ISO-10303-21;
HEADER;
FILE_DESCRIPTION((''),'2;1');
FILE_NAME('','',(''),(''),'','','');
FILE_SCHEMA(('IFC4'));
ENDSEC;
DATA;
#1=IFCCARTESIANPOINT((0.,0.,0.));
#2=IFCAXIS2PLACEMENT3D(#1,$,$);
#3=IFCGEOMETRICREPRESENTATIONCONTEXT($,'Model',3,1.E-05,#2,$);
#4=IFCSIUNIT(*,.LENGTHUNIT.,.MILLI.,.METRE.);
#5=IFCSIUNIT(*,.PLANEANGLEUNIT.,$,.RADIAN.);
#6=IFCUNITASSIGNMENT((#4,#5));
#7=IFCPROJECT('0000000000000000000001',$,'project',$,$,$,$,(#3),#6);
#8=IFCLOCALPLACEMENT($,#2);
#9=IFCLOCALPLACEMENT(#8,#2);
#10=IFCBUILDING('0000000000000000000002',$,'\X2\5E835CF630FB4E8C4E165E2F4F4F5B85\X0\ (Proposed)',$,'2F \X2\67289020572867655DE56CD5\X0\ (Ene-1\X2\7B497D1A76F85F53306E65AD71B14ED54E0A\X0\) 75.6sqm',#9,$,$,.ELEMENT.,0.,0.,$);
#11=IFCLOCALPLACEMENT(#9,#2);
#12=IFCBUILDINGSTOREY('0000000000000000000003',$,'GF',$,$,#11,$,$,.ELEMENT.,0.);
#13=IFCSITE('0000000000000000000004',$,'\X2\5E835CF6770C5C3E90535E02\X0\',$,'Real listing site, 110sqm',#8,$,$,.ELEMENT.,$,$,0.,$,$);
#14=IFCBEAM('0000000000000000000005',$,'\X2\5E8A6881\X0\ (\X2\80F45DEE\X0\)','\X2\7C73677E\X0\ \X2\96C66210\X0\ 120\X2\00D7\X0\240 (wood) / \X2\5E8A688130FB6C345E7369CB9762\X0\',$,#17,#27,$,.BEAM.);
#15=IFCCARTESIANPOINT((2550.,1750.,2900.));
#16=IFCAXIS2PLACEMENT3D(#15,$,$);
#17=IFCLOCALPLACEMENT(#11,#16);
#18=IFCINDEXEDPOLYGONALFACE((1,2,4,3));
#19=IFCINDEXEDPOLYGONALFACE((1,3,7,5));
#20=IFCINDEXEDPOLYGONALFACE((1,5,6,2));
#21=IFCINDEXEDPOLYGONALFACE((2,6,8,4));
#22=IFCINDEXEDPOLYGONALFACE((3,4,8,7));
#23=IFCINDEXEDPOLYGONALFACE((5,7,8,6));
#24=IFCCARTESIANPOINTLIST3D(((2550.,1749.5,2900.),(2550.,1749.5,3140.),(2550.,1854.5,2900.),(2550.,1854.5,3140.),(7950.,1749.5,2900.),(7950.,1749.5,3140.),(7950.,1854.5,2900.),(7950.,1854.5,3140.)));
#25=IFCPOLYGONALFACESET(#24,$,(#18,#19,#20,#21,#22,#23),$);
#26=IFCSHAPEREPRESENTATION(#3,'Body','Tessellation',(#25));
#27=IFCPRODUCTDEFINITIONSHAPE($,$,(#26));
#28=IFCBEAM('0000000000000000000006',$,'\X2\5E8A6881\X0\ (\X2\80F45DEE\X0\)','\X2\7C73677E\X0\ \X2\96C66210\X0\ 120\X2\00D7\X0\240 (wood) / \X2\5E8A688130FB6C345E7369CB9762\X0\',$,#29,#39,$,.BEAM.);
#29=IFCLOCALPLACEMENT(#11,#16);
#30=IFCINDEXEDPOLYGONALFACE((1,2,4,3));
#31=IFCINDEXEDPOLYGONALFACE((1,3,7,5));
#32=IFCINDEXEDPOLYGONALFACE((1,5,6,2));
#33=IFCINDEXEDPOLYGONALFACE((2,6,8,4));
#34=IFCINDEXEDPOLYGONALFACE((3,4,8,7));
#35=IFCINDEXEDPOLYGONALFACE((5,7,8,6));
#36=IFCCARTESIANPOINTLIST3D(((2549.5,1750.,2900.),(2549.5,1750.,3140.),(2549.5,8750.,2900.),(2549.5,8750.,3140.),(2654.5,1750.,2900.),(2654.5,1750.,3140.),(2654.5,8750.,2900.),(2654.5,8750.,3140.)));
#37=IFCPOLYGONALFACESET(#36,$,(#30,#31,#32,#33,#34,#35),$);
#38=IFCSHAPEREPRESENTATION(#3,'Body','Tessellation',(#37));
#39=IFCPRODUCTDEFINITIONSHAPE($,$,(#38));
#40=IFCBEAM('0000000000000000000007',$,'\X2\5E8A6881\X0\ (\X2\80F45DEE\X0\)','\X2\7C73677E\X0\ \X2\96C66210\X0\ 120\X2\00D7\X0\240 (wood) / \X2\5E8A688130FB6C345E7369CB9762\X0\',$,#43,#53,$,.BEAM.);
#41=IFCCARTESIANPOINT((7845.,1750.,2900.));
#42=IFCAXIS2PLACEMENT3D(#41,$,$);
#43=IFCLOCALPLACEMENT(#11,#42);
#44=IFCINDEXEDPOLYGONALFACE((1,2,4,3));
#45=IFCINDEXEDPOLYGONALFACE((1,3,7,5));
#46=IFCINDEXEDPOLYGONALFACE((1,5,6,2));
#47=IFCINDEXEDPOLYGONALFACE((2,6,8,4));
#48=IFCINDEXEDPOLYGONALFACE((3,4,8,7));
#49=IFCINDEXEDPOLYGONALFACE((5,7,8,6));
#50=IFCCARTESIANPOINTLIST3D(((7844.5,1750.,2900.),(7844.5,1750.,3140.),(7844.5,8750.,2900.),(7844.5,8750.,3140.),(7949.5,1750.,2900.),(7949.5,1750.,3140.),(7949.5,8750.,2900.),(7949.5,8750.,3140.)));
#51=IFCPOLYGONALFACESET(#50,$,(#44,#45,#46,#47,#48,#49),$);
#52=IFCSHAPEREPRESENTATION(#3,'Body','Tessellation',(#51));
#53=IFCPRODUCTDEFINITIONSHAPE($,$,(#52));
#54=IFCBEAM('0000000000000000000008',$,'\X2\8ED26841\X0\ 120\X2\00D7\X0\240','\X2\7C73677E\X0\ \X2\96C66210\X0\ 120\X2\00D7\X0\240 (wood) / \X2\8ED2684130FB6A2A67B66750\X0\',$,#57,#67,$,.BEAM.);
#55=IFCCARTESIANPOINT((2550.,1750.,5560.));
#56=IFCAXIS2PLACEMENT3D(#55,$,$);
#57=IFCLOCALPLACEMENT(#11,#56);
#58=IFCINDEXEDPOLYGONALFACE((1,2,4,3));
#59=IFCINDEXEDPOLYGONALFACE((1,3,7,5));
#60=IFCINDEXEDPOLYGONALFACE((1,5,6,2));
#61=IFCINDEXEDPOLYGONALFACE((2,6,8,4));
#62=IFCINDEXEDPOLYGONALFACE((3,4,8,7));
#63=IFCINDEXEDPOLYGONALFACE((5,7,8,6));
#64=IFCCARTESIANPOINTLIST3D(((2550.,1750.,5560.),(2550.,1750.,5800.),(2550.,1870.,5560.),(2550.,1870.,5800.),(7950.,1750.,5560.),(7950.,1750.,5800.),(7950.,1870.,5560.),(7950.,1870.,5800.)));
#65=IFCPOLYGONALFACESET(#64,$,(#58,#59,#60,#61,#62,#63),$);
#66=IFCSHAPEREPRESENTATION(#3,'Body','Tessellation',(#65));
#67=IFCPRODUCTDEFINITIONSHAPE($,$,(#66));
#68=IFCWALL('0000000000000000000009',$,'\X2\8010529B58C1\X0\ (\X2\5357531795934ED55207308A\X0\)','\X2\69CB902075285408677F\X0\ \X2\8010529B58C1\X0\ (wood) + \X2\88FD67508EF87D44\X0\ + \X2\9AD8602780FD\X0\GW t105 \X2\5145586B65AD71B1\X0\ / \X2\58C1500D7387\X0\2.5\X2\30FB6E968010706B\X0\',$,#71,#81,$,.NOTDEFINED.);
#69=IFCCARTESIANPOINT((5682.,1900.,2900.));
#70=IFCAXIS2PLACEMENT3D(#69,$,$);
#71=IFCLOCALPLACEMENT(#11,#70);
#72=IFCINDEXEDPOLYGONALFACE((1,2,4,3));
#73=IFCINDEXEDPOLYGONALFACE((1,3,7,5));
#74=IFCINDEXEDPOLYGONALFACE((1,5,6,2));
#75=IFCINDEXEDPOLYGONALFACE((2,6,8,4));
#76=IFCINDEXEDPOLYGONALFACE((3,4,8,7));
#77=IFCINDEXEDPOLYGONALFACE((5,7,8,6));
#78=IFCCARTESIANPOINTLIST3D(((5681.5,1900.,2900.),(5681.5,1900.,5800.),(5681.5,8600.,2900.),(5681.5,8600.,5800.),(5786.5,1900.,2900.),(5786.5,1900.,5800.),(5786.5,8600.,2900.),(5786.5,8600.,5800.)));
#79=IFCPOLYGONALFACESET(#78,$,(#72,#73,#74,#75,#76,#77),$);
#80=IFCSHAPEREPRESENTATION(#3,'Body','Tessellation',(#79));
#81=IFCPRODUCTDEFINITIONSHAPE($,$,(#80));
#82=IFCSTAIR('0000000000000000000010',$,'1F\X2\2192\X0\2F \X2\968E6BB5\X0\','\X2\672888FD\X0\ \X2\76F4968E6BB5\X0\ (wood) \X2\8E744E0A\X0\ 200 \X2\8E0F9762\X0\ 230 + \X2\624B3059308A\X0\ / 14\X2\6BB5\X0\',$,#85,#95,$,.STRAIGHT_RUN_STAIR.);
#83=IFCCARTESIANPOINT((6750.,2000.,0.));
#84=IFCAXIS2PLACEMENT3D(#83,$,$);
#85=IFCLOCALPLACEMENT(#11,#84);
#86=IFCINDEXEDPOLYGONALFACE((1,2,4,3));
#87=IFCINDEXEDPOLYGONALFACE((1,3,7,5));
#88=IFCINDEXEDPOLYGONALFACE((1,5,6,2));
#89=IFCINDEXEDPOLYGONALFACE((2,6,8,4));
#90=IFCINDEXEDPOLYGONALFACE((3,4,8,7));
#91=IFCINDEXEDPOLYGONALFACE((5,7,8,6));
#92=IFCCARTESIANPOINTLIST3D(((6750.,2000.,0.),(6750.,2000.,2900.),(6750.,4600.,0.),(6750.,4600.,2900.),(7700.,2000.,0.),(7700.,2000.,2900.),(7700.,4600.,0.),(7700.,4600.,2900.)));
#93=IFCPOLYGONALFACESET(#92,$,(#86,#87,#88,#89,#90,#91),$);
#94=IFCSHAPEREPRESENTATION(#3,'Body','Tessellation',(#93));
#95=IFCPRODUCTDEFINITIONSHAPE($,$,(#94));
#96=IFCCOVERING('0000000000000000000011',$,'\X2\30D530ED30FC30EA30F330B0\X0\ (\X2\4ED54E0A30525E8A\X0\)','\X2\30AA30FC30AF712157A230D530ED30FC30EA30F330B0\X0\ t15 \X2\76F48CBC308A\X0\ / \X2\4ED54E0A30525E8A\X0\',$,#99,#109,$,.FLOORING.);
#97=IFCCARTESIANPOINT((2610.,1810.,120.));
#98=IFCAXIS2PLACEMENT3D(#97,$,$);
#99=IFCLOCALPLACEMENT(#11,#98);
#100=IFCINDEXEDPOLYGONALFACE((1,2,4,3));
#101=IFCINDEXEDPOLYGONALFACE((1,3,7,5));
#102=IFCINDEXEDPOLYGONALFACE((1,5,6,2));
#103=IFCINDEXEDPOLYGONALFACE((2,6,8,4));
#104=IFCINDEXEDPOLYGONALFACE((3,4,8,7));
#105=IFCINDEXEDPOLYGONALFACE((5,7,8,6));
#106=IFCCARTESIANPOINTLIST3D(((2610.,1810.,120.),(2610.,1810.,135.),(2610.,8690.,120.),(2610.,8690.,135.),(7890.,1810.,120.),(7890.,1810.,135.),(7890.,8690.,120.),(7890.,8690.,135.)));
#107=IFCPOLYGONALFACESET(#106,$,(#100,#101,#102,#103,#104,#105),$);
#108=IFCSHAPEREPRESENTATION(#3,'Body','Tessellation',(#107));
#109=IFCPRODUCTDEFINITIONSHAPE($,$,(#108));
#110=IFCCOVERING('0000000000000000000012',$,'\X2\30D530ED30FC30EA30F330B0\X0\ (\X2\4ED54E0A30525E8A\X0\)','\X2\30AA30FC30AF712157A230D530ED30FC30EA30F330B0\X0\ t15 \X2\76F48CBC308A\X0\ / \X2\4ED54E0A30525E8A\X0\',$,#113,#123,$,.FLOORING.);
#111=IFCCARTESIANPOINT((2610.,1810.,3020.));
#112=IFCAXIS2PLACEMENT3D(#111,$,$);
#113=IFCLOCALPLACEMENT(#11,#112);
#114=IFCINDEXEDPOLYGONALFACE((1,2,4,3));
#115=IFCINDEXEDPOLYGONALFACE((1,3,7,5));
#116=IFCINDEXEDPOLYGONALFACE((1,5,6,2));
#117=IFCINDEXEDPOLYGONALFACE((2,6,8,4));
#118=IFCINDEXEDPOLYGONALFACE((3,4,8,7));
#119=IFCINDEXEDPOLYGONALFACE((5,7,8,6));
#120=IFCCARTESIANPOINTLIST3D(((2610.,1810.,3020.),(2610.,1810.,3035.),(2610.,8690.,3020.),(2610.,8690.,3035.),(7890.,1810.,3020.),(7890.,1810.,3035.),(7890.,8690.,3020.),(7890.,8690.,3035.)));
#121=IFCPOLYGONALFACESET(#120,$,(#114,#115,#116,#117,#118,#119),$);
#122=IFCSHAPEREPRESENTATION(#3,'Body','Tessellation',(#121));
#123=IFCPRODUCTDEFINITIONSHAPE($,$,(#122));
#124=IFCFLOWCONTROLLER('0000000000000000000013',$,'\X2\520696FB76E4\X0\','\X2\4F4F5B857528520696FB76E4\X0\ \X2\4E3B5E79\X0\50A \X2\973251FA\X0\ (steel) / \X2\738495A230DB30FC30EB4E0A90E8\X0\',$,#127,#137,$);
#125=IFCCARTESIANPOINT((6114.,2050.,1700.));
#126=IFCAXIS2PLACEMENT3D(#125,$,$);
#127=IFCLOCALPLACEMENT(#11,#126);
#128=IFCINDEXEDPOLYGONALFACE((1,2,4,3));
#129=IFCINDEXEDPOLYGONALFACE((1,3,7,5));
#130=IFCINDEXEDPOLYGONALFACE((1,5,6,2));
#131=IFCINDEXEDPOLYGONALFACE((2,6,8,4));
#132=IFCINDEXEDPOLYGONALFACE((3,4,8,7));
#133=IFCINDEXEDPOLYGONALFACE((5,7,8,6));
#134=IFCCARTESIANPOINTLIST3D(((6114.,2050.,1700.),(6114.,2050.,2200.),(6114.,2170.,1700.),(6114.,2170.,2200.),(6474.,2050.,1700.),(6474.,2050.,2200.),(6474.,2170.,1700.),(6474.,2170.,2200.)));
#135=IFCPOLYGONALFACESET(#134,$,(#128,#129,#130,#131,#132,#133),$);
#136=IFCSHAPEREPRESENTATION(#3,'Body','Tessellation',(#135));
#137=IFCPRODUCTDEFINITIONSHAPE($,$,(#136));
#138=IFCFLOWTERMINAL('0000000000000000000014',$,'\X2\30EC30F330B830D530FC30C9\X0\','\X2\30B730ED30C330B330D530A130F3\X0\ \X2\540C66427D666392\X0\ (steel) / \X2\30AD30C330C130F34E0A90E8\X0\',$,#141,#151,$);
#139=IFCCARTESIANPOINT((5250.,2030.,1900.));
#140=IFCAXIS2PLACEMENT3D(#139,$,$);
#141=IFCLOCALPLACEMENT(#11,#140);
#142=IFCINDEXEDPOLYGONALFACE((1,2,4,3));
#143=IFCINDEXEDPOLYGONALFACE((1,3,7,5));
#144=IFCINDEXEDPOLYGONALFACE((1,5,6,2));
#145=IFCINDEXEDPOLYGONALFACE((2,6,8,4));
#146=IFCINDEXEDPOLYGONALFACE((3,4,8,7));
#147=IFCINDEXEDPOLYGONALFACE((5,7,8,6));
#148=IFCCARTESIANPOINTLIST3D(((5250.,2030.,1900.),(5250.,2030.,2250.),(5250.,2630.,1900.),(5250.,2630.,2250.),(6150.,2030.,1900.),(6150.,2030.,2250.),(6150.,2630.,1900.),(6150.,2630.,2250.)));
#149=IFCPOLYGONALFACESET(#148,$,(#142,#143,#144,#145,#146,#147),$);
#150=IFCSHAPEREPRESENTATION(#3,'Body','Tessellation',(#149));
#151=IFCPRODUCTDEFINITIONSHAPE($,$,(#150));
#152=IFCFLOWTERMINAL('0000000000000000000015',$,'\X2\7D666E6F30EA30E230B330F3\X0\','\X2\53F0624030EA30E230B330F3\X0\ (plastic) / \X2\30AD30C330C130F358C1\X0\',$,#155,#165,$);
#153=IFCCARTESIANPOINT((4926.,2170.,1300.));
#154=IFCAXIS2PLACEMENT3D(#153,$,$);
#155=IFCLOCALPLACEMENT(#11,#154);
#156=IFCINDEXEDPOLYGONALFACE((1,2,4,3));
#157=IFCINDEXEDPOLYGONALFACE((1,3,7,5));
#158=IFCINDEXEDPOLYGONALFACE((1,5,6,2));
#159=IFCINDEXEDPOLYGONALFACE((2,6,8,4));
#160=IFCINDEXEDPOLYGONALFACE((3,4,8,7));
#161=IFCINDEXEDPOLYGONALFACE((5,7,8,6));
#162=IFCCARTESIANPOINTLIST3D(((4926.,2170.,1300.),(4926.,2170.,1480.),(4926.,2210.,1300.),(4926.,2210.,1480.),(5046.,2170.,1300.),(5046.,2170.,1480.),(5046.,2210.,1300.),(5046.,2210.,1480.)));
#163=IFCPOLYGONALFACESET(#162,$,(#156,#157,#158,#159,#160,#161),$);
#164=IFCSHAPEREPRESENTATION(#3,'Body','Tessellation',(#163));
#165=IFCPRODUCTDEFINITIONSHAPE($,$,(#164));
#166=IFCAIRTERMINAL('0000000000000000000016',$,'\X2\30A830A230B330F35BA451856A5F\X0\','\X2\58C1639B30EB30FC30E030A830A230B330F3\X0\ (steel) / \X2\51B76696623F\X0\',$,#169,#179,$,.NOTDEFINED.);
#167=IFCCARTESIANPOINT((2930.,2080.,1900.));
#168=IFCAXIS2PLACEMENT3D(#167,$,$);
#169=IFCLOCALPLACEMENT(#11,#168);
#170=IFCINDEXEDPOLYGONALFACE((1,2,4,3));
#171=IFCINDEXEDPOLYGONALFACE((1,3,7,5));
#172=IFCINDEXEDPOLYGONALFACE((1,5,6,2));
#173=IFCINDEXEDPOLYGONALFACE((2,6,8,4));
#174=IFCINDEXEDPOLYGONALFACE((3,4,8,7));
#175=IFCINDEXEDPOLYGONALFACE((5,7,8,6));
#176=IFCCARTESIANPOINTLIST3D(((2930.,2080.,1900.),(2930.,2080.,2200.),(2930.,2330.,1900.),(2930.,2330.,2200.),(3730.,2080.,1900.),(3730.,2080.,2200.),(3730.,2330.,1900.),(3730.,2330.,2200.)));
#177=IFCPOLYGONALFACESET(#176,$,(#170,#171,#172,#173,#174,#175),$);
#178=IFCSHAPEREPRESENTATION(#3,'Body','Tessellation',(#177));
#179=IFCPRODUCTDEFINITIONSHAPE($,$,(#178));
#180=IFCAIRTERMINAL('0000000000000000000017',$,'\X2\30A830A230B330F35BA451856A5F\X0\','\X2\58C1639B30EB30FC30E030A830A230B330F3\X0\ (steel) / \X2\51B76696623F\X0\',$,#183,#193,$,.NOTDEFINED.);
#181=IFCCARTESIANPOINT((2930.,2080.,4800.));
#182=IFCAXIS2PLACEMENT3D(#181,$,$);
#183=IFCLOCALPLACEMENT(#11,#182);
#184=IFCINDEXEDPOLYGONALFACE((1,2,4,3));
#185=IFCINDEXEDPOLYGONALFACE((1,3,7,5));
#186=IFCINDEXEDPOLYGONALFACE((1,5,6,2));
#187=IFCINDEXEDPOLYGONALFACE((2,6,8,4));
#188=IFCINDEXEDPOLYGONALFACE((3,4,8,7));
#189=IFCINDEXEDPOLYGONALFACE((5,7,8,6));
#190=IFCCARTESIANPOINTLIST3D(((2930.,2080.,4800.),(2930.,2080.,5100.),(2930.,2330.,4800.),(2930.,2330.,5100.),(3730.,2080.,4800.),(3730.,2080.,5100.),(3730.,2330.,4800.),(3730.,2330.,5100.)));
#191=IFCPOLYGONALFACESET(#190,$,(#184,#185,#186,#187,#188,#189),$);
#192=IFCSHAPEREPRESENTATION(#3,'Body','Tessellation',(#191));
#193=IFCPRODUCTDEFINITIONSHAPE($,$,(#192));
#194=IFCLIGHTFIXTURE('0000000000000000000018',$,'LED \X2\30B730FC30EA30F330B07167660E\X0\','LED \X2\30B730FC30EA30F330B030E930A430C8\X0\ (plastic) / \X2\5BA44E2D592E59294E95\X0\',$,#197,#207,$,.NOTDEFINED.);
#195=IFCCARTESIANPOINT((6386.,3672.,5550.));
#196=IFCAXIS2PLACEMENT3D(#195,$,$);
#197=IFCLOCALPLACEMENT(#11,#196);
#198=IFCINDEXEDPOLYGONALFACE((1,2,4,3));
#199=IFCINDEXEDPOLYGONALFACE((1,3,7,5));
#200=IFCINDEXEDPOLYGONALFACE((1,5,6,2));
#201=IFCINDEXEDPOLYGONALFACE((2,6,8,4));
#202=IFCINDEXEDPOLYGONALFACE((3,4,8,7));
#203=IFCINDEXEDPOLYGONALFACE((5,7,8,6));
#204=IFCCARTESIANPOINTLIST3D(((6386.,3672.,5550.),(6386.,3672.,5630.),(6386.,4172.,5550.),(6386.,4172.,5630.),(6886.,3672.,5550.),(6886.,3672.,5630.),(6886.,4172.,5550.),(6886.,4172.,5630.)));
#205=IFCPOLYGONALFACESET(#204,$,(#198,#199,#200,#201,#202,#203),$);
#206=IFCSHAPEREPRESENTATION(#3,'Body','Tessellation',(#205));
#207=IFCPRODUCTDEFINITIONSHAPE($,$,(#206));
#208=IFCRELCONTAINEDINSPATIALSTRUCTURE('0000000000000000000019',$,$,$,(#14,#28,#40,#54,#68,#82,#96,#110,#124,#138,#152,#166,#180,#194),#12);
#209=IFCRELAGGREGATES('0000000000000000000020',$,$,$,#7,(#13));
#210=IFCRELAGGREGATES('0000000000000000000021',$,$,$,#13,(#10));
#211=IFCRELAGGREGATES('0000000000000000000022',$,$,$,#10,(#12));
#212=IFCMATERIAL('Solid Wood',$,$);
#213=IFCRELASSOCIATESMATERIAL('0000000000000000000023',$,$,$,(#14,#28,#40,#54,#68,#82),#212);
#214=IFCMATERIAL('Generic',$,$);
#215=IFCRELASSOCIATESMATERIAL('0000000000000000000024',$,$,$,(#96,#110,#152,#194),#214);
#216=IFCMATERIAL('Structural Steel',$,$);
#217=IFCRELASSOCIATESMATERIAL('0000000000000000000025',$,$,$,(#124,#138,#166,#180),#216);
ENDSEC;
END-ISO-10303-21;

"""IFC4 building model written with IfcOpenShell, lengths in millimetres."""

from ifc_helpers import new_model, si_unit, frame, frame_2d, origin, place, context, project, spatial, rectangle, extrude, material, element, save


model = new_model("IFC4")

# Units and contexts
model_context = context("Model", 3, precision=1e-05, world=origin())
ifc_project = project(units=[si_unit("LENGTHUNIT", "METRE", prefix="MILLI"), si_unit("PLANEANGLEUNIT", "RADIAN")], contexts=[model_context])

# Site, building, storey
site_placement = place(None, origin())
site = spatial("IfcSite", under=ifc_project, at=site_placement, Name="広島県尾道市", ObjectType="Real listing site, 110sqm", CompositionType="ELEMENT", RefElevation=0.0)
building_placement = place(site_placement, origin())
building = spatial("IfcBuilding", under=site, at=building_placement, Name="広島・二世帯住宅 (Proposed)", ObjectType="2F 木造在来工法 (Ene-1等級相当の断熱仕上) 75.6sqm", CompositionType="ELEMENT", ElevationOfRefHeight=0.0, ElevationOfTerrain=0.0)
storey_placement = place(building_placement, origin())
storey = spatial("IfcBuildingStorey", under=building, at=storey_placement, Name="GF", CompositionType="ELEMENT", Elevation=0.0)

# Shared definitions
ifc_material_1 = material(Name="Solid Wood")

# Beams
beam_1_placement = place(storey_placement, frame((2550.0, 1750.0, 2900.0)))
element("IfcBeam", 1, at=beam_1_placement, inside=storey, material=ifc_material_1, Name="床梁 (胴差)", Description="米松 集成 120×240 (wood) / 床梁・水平構面", PredefinedType="BEAM", context=model_context, shape_type="SweptSolid", body=[
    extrude(rectangle(XDim=5400.0, YDim=105.0, at=frame_2d((2700.0, 52.0))), frame((2550.0, 1750.0, 2900.0)), (0.0, 0.0, 1.0), 240.0),
])
beam_2_placement = place(storey_placement, frame((2550.0, 1750.0, 2900.0)))
element("IfcBeam", 2, at=beam_2_placement, inside=storey, material=ifc_material_1, Name="床梁 (胴差)", Description="米松 集成 120×240 (wood) / 床梁・水平構面", PredefinedType="BEAM", context=model_context, shape_type="SweptSolid", body=[
    extrude(rectangle(XDim=105.0, YDim=7000.0, at=frame_2d((52.0, 3500.0))), frame((2550.0, 1750.0, 2900.0)), (0.0, 0.0, 1.0), 240.0),
])
beam_3_placement = place(storey_placement, frame((7845.0, 1750.0, 2900.0)))
element("IfcBeam", 3, at=beam_3_placement, inside=storey, material=ifc_material_1, Name="床梁 (胴差)", Description="米松 集成 120×240 (wood) / 床梁・水平構面", PredefinedType="BEAM", context=model_context, shape_type="SweptSolid", body=[
    extrude(rectangle(XDim=105.0, YDim=7000.0, at=frame_2d((52.0, 3500.0))), frame((7845.0, 1750.0, 2900.0)), (0.0, 0.0, 1.0), 240.0),
])
beam_4_placement = place(storey_placement, frame((2550.0, 1750.0, 5560.0)))
element("IfcBeam", 4, at=beam_4_placement, inside=storey, material=ifc_material_1, Name="軒桁 120×240", Description="米松 集成 120×240 (wood) / 軒桁・横架材", PredefinedType="BEAM", context=model_context, shape_type="SweptSolid", body=[
    extrude(rectangle(XDim=5400.0, YDim=120.0, at=frame_2d((2700.0, 60.0))), frame((2550.0, 1750.0, 5560.0)), (0.0, 0.0, 1.0), 240.0),
])

# Wall
wall_1_placement = place(storey_placement, frame((5682.0, 1900.0, 2900.0)))
element("IfcWall", 5, at=wall_1_placement, inside=storey, material=ifc_material_1, Name="耐力壁 (南北間仕切り)", Description="構造用合板 耐力壁 (wood) + 製材軸組 + 高性能GW t105 充填断熱 / 壁倍率2.5・準耐火", PredefinedType="NOTDEFINED", context=model_context, shape_type="SweptSolid", body=[
    extrude(rectangle(XDim=105.0, YDim=6700.0, at=frame_2d((52.0, 3350.0))), frame((5682.0, 1900.0, 2900.0)), (0.0, 0.0, 1.0), 2900.0),
])

# Stair
stair_placement = place(storey_placement, frame((6750.0, 2000.0, 0.0)))
element("IfcStair", 6, at=stair_placement, inside=storey, material=ifc_material_1, Name="1F→2F 階段", Description="木製 直階段 (wood) 蹴上 200 踏面 230 + 手すり / 14段", PredefinedType="STRAIGHT_RUN_STAIR", context=model_context, shape_type="SweptSolid", body=[
    extrude(rectangle(XDim=950.0, YDim=2600.0, at=frame_2d((475.0, 1300.0))), frame((6750.0, 2000.0, 0.0)), (0.0, 0.0, 1.0), 2900.0),
])

# Coverings
ifc_material_2 = material(Name="Generic")
covering_1_placement = place(storey_placement, frame((2610.0, 1810.0, 120.0)))
element("IfcCovering", 7, at=covering_1_placement, inside=storey, material=ifc_material_2, Name="フローリング (仕上げ床)", Description="オーク無垢フローリング t15 直貼り / 仕上げ床", PredefinedType="FLOORING", context=model_context, shape_type="SweptSolid", body=[
    extrude(rectangle(XDim=5280.0, YDim=6880.0, at=frame_2d((2640.0, 3440.0))), frame((2610.0, 1810.0, 120.0)), (0.0, 0.0, 1.0), 15.0),
])
covering_2_placement = place(storey_placement, frame((2610.0, 1810.0, 3020.0)))
element("IfcCovering", 8, at=covering_2_placement, inside=storey, material=ifc_material_2, Name="フローリング (仕上げ床)", Description="オーク無垢フローリング t15 直貼り / 仕上げ床", PredefinedType="FLOORING", context=model_context, shape_type="SweptSolid", body=[
    extrude(rectangle(XDim=5280.0, YDim=6880.0, at=frame_2d((2640.0, 3440.0))), frame((2610.0, 1810.0, 3020.0)), (0.0, 0.0, 1.0), 15.0),
])

# Flow controller
ifc_material_3 = material(Name="Structural Steel")
flow_controller_placement = place(storey_placement, frame((6114.0, 2050.0, 1700.0)))
element("IfcFlowController", 9, at=flow_controller_placement, inside=storey, material=ifc_material_3, Name="分電盤", Description="住宅用分電盤 主幹50A 露出 (steel) / 玄関ホール上部", context=model_context, shape_type="SweptSolid", body=[
    extrude(rectangle(XDim=360.0, YDim=120.0, at=frame_2d((180.0, 60.0))), frame((6114.0, 2050.0, 1700.0)), (0.0, 0.0, 1.0), 500.0),
])

# Flow terminals
flow_terminal_1_placement = place(storey_placement, frame((5250.0, 2030.0, 1900.0)))
element("IfcFlowTerminal", 10, at=flow_terminal_1_placement, inside=storey, material=ifc_material_3, Name="レンジフード", Description="シロッコファン 同時給排 (steel) / キッチン上部", context=model_context, shape_type="SweptSolid", body=[
    extrude(rectangle(XDim=900.0, YDim=600.0, at=frame_2d((450.0, 300.0))), frame((5250.0, 2030.0, 1900.0)), (0.0, 0.0, 1.0), 350.0),
])
flow_terminal_2_placement = place(storey_placement, frame((4926.0, 2170.0, 1300.0)))
element("IfcFlowTerminal", 11, at=flow_terminal_2_placement, inside=storey, material=ifc_material_2, Name="給湯リモコン", Description="台所リモコン (plastic) / キッチン壁", context=model_context, shape_type="SweptSolid", body=[
    extrude(rectangle(XDim=120.0, YDim=40.0, at=frame_2d((60.0, 20.0))), frame((4926.0, 2170.0, 1300.0)), (0.0, 0.0, 1.0), 180.0),
])

# Air terminals
air_terminal_1_placement = place(storey_placement, frame((2930.0, 2080.0, 1900.0)))
element("IfcAirTerminal", 12, at=air_terminal_1_placement, inside=storey, material=ifc_material_3, Name="エアコン室内機", Description="壁掛ルームエアコン (steel) / 冷暖房", PredefinedType="NOTDEFINED", context=model_context, shape_type="SweptSolid", body=[
    extrude(rectangle(XDim=800.0, YDim=250.0, at=frame_2d((400.0, 125.0))), frame((2930.0, 2080.0, 1900.0)), (0.0, 0.0, 1.0), 300.0),
])
air_terminal_2_placement = place(storey_placement, frame((2930.0, 2080.0, 4800.0)))
element("IfcAirTerminal", 13, at=air_terminal_2_placement, inside=storey, material=ifc_material_3, Name="エアコン室内機", Description="壁掛ルームエアコン (steel) / 冷暖房", PredefinedType="NOTDEFINED", context=model_context, shape_type="SweptSolid", body=[
    extrude(rectangle(XDim=800.0, YDim=250.0, at=frame_2d((400.0, 125.0))), frame((2930.0, 2080.0, 4800.0)), (0.0, 0.0, 1.0), 300.0),
])

# Light fixture
light_fixture_placement = place(storey_placement, frame((6386.0, 3672.0, 5550.0)))
element("IfcLightFixture", 14, at=light_fixture_placement, inside=storey, material=ifc_material_2, Name="LED シーリング照明", Description="LED シーリングライト (plastic) / 室中央天井", PredefinedType="NOTDEFINED", context=model_context, shape_type="SweptSolid", body=[
    extrude(rectangle(XDim=500.0, YDim=500.0, at=frame_2d((250.0, 250.0))), frame((6386.0, 3672.0, 5550.0)), (0.0, 0.0, 1.0), 80.0),
])

save(model, "model.ifc")
